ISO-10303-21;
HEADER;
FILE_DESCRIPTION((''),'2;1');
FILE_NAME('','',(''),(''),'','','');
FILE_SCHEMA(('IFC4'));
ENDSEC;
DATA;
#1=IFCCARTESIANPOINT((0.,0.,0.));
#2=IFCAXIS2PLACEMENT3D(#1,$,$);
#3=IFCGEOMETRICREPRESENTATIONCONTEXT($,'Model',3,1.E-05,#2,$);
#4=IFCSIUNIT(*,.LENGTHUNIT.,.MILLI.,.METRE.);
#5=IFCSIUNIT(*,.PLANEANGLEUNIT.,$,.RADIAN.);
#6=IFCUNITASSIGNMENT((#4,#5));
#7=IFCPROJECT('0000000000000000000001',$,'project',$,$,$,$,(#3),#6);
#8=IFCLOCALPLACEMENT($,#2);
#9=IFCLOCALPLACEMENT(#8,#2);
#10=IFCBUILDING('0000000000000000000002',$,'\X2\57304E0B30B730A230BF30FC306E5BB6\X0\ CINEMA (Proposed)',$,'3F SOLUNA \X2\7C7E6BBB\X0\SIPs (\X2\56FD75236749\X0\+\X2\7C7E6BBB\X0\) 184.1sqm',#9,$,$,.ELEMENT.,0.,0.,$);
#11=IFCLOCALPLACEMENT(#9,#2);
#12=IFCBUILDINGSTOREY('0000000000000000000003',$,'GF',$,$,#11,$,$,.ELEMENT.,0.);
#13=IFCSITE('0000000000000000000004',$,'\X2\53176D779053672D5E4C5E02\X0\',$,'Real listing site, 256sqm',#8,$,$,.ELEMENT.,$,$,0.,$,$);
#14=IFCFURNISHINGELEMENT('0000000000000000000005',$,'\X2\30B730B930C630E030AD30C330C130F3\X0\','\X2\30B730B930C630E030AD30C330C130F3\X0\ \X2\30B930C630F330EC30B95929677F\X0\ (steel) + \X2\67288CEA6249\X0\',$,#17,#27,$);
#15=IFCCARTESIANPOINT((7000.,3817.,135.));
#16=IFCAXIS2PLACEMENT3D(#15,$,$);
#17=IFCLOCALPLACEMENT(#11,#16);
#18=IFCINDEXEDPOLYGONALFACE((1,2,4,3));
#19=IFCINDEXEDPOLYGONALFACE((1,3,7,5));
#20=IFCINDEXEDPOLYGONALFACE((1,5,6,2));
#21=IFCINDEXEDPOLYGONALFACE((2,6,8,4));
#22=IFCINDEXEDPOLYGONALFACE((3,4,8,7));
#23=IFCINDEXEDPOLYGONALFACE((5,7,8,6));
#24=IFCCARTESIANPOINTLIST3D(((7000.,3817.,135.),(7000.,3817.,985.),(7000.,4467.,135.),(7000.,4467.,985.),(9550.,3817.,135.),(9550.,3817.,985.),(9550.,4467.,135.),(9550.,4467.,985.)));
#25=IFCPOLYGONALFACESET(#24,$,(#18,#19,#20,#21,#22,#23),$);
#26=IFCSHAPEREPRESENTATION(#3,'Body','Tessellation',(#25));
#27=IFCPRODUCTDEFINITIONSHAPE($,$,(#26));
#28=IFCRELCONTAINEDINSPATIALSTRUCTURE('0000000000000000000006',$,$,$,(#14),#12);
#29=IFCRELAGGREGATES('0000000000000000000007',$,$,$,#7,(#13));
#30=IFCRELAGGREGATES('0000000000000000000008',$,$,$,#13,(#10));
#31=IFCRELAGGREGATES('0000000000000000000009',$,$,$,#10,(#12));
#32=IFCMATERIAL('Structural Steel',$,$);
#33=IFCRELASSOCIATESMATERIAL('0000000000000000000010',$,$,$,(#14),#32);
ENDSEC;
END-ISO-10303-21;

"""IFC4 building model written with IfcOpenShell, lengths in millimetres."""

from ifc_helpers import new_model, si_unit, frame, frame_2d, origin, place, context, project, spatial, rectangle, extrude, material, element, save


model = new_model("IFC4")

# Units and contexts
model_context = context("Model", 3, precision=1e-05, world=origin())
ifc_project = project(units=[si_unit("LENGTHUNIT", "METRE", prefix="MILLI"), si_unit("PLANEANGLEUNIT", "RADIAN")], contexts=[model_context])

# Site, building, storey
site_placement = place(None, origin())
site = spatial("IfcSite", under=ifc_project, at=site_placement, Name="北海道札幌市", ObjectType="Real listing site, 256sqm", CompositionType="ELEMENT", RefElevation=0.0)
building_placement = place(site_placement, origin())
building = spatial("IfcBuilding", under=site, at=building_placement, Name="地下シアターの家 CINEMA (Proposed)", ObjectType="3F SOLUNA 籾殻SIPs (国産杉+籾殻) 184.1sqm", CompositionType="ELEMENT", ElevationOfRefHeight=0.0, ElevationOfTerrain=0.0)
storey_placement = place(building_placement, origin())
storey = spatial("IfcBuildingStorey", under=building, at=storey_placement, Name="GF", CompositionType="ELEMENT", Elevation=0.0)

# Furnishing element
ifc_material_1 = material(Name="Structural Steel")
furnishing_1_placement = place(storey_placement, frame((7000.0, 3817.0, 135.0)))
element("IfcFurnishingElement", 1, at=furnishing_1_placement, inside=storey, material=ifc_material_1, Name="システムキッチン", Description="システムキッチン ステンレス天板 (steel) + 木質扉", context=model_context, shape_type="SweptSolid", body=[
    extrude(rectangle(XDim=2550.0, YDim=650.0, at=frame_2d((1275.0, 325.0))), frame((7000.0, 3817.0, 135.0)), (0.0, 0.0, 1.0), 850.0),
])

save(model, "model.ifc")
